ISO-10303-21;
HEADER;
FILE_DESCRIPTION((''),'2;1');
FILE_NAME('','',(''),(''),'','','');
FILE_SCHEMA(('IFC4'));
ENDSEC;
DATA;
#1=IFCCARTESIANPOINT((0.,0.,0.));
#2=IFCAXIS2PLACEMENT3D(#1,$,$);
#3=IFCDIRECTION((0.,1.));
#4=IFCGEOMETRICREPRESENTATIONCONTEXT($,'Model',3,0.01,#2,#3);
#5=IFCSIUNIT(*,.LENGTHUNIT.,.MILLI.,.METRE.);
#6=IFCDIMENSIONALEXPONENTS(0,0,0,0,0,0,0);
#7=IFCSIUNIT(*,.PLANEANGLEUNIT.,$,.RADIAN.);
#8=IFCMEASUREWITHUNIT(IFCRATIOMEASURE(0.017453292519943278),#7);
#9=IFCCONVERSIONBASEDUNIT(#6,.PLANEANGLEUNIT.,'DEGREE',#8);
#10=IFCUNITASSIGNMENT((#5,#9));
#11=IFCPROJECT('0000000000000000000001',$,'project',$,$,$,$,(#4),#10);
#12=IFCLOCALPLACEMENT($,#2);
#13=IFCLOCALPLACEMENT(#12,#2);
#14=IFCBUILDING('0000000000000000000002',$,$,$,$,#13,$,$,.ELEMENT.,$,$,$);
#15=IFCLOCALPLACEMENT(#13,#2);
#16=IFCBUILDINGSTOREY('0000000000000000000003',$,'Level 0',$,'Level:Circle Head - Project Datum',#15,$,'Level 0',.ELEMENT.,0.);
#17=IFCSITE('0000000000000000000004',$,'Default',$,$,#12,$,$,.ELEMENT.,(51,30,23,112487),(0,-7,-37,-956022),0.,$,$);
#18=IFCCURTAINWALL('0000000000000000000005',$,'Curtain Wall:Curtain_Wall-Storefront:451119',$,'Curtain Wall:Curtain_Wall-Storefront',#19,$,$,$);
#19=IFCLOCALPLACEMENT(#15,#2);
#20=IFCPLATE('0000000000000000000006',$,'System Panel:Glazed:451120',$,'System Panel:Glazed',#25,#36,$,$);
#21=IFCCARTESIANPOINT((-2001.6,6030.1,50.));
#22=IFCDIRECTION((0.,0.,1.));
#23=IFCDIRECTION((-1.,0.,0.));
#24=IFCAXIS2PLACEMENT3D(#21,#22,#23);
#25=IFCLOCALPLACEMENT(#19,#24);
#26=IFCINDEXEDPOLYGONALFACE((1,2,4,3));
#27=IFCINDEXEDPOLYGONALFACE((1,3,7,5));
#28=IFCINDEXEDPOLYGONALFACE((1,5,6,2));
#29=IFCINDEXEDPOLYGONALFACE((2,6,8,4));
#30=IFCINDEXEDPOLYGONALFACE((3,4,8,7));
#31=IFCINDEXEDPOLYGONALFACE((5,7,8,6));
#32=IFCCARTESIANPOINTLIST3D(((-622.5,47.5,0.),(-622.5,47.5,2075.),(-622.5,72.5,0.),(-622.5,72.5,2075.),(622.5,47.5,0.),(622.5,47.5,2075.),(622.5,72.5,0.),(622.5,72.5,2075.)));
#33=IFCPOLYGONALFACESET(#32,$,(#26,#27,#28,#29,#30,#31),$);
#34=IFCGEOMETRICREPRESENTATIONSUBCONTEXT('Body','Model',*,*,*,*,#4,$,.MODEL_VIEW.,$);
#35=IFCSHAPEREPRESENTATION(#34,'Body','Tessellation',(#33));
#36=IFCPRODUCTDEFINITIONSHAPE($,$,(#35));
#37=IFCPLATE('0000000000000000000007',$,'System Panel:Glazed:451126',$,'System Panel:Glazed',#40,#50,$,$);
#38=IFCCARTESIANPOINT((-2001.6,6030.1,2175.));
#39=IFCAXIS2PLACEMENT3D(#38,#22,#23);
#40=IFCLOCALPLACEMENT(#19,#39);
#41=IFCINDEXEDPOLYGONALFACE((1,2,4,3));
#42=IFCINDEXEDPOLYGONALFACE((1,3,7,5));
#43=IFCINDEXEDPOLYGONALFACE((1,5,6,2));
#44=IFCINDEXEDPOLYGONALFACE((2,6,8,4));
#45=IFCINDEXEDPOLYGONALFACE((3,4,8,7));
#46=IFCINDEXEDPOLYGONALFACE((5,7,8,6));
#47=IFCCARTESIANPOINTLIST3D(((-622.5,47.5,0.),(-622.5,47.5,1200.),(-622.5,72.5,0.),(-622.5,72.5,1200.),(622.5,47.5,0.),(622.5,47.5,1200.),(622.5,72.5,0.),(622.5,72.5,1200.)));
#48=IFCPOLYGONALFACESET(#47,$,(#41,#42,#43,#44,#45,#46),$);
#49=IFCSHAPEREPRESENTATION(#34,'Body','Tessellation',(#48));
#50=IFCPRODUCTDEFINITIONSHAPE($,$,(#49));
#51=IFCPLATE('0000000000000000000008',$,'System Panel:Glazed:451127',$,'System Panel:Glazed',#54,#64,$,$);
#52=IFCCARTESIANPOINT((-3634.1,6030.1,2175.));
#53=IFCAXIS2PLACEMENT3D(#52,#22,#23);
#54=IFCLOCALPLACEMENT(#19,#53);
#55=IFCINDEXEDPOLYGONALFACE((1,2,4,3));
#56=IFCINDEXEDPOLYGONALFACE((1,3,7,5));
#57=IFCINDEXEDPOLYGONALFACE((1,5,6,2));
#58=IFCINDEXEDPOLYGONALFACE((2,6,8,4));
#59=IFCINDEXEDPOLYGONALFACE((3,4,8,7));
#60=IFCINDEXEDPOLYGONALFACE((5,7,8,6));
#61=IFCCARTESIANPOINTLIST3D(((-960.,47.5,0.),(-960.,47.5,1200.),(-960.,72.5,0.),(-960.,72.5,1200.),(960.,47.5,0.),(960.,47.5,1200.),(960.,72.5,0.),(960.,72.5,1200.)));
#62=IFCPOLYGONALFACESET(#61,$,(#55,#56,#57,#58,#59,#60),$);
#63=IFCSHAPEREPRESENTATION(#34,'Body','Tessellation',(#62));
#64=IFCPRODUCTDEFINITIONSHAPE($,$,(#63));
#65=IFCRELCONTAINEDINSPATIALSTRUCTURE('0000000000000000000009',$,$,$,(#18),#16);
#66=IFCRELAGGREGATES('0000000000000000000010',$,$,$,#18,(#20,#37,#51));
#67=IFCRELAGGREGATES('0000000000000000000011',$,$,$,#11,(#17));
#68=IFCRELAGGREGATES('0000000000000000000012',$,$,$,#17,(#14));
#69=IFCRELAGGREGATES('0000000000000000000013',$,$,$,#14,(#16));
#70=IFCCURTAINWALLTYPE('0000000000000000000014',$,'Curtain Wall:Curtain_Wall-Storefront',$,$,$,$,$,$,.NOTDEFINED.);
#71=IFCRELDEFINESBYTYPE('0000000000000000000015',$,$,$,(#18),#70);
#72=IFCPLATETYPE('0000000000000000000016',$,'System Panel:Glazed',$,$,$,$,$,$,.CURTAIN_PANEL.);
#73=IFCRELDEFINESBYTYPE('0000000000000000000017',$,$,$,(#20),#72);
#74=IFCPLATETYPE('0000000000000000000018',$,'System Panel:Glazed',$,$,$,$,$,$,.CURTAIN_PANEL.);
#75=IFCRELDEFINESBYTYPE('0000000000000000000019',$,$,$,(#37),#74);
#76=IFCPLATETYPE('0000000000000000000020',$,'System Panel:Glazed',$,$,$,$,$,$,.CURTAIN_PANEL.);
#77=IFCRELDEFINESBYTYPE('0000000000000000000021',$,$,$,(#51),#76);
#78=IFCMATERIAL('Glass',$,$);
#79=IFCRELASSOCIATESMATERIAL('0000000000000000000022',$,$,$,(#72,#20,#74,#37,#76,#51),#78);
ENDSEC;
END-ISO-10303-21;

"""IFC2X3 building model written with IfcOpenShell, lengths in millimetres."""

from ifc_helpers import new_model, entity, si_unit, converted_unit, direction, frame, origin, origin_2d_with_axis, place, context, subcontext, project, spatial, rectangle, extrude, source, transform, mapped, material, type_object, type_shapes, element, aggregate, save


model = new_model("IFC2X3")

# Units and contexts
model_context = context("Model", 3, precision=0.01, world=origin(), true_north=direction((0.0, 1.0)))
body_context = subcontext(model_context, "Body", "Model", "MODEL_VIEW")
ifc_project = project(units=[si_unit("LENGTHUNIT", "METRE", prefix="MILLI"), converted_unit("PLANEANGLEUNIT", "DEGREE", entity("IfcRatioMeasure", 0.017453292519943278), si_unit("PLANEANGLEUNIT", "RADIAN"), dimensions=[0, 0, 0, 0, 0, 0, 0])], contexts=[model_context])

# Site, building, storey
site_placement = place(None, origin())
site = spatial("IfcSite", under=ifc_project, at=site_placement, Name="Default", CompositionType="ELEMENT", RefLatitude=(51, 30, 23, 112487), RefLongitude=(0, -7, -37, -956022), RefElevation=0.0)
building_placement = place(site_placement, origin())
building = spatial("IfcBuilding", under=site, at=building_placement, CompositionType="ELEMENT")
storey_placement = place(building_placement, origin())
storey = spatial("IfcBuildingStorey", under=building, at=storey_placement, Name="Level 0", ObjectType="Level:Circle Head - Project Datum", LongName="Level 0", CompositionType="ELEMENT", Elevation=0.0)

# Curtain wall
curtain_wall_type = type_object("IfcCurtainWallType", Name="Curtain Wall:Curtain_Wall-Storefront", PredefinedType="NOTDEFINED")
curtain_wall_placement = place(storey_placement, origin())
curtain_wall = element("IfcCurtainWall", 1, at=curtain_wall_placement, inside=storey, type_object=curtain_wall_type, Name="Curtain Wall:Curtain_Wall-Storefront:451119", ObjectType="Curtain Wall:Curtain_Wall-Storefront")

# Plates
ifc_material_1 = material(Name="Glass")
plate_type_1 = type_object("IfcPlateType", Name="System Panel:Glazed", PredefinedType="CURTAIN_PANEL", material=ifc_material_1)
shared_shape_1 = source(origin(), body_context, "Body", "SweptSolid", [
    extrude(rectangle(XDim=25.0, YDim=1245.0, at=origin_2d_with_axis()), frame((0.0, 60.0, 0.0), z_axis=(0.0, 0.0, 1.0), x_axis=(0.0, 1.0, 0.0)), (0.0, 0.0, 1.0), 2075.0),
])
type_shapes(plate_type_1, [shared_shape_1])
plate_1_placement = place(curtain_wall_placement, frame((-2001.6, 6030.1, 50.0), z_axis=(0.0, 0.0, 1.0), x_axis=(-1.0, 0.0, 0.0)))
plate_1 = element("IfcPlate", 2, at=plate_1_placement, type_object=plate_type_1, material=ifc_material_1, Name="System Panel:Glazed:451120", ObjectType="System Panel:Glazed", context=body_context, shape_type="MappedRepresentation", body=[
    mapped(shared_shape_1, transform((0.0, 0.0, 0.0), scale=1.0)),
])
plate_type_2 = type_object("IfcPlateType", Name="System Panel:Glazed", PredefinedType="CURTAIN_PANEL", material=ifc_material_1)
shared_shape_2 = source(origin(), body_context, "Body", "SweptSolid", [
    extrude(rectangle(XDim=25.0, YDim=1245.0, at=origin_2d_with_axis()), frame((0.0, 60.0, 0.0), z_axis=(0.0, 0.0, 1.0), x_axis=(0.0, 1.0, 0.0)), (0.0, 0.0, 1.0), 1200.0),
])
type_shapes(plate_type_2, [shared_shape_2])
plate_2_placement = place(curtain_wall_placement, frame((-2001.6, 6030.1, 2175.0), z_axis=(0.0, 0.0, 1.0), x_axis=(-1.0, 0.0, 0.0)))
plate_2 = element("IfcPlate", 3, at=plate_2_placement, type_object=plate_type_2, material=ifc_material_1, Name="System Panel:Glazed:451126", ObjectType="System Panel:Glazed", context=body_context, shape_type="MappedRepresentation", body=[
    mapped(shared_shape_2, transform((0.0, 0.0, 0.0), scale=1.0)),
])
plate_type_3 = type_object("IfcPlateType", Name="System Panel:Glazed", PredefinedType="CURTAIN_PANEL", material=ifc_material_1)
shared_shape_3 = source(origin(), body_context, "Body", "SweptSolid", [
    extrude(rectangle(XDim=25.0, YDim=1920.0, at=origin_2d_with_axis()), frame((0.0, 60.0, 0.0), z_axis=(0.0, 0.0, 1.0), x_axis=(0.0, 1.0, 0.0)), (0.0, 0.0, 1.0), 1200.0),
])
type_shapes(plate_type_3, [shared_shape_3])
plate_3_placement = place(curtain_wall_placement, frame((-3634.1, 6030.1, 2175.0), z_axis=(0.0, 0.0, 1.0), x_axis=(-1.0, 0.0, 0.0)))
plate_3 = element("IfcPlate", 4, at=plate_3_placement, type_object=plate_type_3, material=ifc_material_1, Name="System Panel:Glazed:451127", ObjectType="System Panel:Glazed", context=body_context, shape_type="MappedRepresentation", body=[
    mapped(shared_shape_3, transform((0.0, 0.0, 0.0), scale=1.0)),
])
aggregate(curtain_wall, [plate_1, plate_2, plate_3])

save(model, "model.ifc")
